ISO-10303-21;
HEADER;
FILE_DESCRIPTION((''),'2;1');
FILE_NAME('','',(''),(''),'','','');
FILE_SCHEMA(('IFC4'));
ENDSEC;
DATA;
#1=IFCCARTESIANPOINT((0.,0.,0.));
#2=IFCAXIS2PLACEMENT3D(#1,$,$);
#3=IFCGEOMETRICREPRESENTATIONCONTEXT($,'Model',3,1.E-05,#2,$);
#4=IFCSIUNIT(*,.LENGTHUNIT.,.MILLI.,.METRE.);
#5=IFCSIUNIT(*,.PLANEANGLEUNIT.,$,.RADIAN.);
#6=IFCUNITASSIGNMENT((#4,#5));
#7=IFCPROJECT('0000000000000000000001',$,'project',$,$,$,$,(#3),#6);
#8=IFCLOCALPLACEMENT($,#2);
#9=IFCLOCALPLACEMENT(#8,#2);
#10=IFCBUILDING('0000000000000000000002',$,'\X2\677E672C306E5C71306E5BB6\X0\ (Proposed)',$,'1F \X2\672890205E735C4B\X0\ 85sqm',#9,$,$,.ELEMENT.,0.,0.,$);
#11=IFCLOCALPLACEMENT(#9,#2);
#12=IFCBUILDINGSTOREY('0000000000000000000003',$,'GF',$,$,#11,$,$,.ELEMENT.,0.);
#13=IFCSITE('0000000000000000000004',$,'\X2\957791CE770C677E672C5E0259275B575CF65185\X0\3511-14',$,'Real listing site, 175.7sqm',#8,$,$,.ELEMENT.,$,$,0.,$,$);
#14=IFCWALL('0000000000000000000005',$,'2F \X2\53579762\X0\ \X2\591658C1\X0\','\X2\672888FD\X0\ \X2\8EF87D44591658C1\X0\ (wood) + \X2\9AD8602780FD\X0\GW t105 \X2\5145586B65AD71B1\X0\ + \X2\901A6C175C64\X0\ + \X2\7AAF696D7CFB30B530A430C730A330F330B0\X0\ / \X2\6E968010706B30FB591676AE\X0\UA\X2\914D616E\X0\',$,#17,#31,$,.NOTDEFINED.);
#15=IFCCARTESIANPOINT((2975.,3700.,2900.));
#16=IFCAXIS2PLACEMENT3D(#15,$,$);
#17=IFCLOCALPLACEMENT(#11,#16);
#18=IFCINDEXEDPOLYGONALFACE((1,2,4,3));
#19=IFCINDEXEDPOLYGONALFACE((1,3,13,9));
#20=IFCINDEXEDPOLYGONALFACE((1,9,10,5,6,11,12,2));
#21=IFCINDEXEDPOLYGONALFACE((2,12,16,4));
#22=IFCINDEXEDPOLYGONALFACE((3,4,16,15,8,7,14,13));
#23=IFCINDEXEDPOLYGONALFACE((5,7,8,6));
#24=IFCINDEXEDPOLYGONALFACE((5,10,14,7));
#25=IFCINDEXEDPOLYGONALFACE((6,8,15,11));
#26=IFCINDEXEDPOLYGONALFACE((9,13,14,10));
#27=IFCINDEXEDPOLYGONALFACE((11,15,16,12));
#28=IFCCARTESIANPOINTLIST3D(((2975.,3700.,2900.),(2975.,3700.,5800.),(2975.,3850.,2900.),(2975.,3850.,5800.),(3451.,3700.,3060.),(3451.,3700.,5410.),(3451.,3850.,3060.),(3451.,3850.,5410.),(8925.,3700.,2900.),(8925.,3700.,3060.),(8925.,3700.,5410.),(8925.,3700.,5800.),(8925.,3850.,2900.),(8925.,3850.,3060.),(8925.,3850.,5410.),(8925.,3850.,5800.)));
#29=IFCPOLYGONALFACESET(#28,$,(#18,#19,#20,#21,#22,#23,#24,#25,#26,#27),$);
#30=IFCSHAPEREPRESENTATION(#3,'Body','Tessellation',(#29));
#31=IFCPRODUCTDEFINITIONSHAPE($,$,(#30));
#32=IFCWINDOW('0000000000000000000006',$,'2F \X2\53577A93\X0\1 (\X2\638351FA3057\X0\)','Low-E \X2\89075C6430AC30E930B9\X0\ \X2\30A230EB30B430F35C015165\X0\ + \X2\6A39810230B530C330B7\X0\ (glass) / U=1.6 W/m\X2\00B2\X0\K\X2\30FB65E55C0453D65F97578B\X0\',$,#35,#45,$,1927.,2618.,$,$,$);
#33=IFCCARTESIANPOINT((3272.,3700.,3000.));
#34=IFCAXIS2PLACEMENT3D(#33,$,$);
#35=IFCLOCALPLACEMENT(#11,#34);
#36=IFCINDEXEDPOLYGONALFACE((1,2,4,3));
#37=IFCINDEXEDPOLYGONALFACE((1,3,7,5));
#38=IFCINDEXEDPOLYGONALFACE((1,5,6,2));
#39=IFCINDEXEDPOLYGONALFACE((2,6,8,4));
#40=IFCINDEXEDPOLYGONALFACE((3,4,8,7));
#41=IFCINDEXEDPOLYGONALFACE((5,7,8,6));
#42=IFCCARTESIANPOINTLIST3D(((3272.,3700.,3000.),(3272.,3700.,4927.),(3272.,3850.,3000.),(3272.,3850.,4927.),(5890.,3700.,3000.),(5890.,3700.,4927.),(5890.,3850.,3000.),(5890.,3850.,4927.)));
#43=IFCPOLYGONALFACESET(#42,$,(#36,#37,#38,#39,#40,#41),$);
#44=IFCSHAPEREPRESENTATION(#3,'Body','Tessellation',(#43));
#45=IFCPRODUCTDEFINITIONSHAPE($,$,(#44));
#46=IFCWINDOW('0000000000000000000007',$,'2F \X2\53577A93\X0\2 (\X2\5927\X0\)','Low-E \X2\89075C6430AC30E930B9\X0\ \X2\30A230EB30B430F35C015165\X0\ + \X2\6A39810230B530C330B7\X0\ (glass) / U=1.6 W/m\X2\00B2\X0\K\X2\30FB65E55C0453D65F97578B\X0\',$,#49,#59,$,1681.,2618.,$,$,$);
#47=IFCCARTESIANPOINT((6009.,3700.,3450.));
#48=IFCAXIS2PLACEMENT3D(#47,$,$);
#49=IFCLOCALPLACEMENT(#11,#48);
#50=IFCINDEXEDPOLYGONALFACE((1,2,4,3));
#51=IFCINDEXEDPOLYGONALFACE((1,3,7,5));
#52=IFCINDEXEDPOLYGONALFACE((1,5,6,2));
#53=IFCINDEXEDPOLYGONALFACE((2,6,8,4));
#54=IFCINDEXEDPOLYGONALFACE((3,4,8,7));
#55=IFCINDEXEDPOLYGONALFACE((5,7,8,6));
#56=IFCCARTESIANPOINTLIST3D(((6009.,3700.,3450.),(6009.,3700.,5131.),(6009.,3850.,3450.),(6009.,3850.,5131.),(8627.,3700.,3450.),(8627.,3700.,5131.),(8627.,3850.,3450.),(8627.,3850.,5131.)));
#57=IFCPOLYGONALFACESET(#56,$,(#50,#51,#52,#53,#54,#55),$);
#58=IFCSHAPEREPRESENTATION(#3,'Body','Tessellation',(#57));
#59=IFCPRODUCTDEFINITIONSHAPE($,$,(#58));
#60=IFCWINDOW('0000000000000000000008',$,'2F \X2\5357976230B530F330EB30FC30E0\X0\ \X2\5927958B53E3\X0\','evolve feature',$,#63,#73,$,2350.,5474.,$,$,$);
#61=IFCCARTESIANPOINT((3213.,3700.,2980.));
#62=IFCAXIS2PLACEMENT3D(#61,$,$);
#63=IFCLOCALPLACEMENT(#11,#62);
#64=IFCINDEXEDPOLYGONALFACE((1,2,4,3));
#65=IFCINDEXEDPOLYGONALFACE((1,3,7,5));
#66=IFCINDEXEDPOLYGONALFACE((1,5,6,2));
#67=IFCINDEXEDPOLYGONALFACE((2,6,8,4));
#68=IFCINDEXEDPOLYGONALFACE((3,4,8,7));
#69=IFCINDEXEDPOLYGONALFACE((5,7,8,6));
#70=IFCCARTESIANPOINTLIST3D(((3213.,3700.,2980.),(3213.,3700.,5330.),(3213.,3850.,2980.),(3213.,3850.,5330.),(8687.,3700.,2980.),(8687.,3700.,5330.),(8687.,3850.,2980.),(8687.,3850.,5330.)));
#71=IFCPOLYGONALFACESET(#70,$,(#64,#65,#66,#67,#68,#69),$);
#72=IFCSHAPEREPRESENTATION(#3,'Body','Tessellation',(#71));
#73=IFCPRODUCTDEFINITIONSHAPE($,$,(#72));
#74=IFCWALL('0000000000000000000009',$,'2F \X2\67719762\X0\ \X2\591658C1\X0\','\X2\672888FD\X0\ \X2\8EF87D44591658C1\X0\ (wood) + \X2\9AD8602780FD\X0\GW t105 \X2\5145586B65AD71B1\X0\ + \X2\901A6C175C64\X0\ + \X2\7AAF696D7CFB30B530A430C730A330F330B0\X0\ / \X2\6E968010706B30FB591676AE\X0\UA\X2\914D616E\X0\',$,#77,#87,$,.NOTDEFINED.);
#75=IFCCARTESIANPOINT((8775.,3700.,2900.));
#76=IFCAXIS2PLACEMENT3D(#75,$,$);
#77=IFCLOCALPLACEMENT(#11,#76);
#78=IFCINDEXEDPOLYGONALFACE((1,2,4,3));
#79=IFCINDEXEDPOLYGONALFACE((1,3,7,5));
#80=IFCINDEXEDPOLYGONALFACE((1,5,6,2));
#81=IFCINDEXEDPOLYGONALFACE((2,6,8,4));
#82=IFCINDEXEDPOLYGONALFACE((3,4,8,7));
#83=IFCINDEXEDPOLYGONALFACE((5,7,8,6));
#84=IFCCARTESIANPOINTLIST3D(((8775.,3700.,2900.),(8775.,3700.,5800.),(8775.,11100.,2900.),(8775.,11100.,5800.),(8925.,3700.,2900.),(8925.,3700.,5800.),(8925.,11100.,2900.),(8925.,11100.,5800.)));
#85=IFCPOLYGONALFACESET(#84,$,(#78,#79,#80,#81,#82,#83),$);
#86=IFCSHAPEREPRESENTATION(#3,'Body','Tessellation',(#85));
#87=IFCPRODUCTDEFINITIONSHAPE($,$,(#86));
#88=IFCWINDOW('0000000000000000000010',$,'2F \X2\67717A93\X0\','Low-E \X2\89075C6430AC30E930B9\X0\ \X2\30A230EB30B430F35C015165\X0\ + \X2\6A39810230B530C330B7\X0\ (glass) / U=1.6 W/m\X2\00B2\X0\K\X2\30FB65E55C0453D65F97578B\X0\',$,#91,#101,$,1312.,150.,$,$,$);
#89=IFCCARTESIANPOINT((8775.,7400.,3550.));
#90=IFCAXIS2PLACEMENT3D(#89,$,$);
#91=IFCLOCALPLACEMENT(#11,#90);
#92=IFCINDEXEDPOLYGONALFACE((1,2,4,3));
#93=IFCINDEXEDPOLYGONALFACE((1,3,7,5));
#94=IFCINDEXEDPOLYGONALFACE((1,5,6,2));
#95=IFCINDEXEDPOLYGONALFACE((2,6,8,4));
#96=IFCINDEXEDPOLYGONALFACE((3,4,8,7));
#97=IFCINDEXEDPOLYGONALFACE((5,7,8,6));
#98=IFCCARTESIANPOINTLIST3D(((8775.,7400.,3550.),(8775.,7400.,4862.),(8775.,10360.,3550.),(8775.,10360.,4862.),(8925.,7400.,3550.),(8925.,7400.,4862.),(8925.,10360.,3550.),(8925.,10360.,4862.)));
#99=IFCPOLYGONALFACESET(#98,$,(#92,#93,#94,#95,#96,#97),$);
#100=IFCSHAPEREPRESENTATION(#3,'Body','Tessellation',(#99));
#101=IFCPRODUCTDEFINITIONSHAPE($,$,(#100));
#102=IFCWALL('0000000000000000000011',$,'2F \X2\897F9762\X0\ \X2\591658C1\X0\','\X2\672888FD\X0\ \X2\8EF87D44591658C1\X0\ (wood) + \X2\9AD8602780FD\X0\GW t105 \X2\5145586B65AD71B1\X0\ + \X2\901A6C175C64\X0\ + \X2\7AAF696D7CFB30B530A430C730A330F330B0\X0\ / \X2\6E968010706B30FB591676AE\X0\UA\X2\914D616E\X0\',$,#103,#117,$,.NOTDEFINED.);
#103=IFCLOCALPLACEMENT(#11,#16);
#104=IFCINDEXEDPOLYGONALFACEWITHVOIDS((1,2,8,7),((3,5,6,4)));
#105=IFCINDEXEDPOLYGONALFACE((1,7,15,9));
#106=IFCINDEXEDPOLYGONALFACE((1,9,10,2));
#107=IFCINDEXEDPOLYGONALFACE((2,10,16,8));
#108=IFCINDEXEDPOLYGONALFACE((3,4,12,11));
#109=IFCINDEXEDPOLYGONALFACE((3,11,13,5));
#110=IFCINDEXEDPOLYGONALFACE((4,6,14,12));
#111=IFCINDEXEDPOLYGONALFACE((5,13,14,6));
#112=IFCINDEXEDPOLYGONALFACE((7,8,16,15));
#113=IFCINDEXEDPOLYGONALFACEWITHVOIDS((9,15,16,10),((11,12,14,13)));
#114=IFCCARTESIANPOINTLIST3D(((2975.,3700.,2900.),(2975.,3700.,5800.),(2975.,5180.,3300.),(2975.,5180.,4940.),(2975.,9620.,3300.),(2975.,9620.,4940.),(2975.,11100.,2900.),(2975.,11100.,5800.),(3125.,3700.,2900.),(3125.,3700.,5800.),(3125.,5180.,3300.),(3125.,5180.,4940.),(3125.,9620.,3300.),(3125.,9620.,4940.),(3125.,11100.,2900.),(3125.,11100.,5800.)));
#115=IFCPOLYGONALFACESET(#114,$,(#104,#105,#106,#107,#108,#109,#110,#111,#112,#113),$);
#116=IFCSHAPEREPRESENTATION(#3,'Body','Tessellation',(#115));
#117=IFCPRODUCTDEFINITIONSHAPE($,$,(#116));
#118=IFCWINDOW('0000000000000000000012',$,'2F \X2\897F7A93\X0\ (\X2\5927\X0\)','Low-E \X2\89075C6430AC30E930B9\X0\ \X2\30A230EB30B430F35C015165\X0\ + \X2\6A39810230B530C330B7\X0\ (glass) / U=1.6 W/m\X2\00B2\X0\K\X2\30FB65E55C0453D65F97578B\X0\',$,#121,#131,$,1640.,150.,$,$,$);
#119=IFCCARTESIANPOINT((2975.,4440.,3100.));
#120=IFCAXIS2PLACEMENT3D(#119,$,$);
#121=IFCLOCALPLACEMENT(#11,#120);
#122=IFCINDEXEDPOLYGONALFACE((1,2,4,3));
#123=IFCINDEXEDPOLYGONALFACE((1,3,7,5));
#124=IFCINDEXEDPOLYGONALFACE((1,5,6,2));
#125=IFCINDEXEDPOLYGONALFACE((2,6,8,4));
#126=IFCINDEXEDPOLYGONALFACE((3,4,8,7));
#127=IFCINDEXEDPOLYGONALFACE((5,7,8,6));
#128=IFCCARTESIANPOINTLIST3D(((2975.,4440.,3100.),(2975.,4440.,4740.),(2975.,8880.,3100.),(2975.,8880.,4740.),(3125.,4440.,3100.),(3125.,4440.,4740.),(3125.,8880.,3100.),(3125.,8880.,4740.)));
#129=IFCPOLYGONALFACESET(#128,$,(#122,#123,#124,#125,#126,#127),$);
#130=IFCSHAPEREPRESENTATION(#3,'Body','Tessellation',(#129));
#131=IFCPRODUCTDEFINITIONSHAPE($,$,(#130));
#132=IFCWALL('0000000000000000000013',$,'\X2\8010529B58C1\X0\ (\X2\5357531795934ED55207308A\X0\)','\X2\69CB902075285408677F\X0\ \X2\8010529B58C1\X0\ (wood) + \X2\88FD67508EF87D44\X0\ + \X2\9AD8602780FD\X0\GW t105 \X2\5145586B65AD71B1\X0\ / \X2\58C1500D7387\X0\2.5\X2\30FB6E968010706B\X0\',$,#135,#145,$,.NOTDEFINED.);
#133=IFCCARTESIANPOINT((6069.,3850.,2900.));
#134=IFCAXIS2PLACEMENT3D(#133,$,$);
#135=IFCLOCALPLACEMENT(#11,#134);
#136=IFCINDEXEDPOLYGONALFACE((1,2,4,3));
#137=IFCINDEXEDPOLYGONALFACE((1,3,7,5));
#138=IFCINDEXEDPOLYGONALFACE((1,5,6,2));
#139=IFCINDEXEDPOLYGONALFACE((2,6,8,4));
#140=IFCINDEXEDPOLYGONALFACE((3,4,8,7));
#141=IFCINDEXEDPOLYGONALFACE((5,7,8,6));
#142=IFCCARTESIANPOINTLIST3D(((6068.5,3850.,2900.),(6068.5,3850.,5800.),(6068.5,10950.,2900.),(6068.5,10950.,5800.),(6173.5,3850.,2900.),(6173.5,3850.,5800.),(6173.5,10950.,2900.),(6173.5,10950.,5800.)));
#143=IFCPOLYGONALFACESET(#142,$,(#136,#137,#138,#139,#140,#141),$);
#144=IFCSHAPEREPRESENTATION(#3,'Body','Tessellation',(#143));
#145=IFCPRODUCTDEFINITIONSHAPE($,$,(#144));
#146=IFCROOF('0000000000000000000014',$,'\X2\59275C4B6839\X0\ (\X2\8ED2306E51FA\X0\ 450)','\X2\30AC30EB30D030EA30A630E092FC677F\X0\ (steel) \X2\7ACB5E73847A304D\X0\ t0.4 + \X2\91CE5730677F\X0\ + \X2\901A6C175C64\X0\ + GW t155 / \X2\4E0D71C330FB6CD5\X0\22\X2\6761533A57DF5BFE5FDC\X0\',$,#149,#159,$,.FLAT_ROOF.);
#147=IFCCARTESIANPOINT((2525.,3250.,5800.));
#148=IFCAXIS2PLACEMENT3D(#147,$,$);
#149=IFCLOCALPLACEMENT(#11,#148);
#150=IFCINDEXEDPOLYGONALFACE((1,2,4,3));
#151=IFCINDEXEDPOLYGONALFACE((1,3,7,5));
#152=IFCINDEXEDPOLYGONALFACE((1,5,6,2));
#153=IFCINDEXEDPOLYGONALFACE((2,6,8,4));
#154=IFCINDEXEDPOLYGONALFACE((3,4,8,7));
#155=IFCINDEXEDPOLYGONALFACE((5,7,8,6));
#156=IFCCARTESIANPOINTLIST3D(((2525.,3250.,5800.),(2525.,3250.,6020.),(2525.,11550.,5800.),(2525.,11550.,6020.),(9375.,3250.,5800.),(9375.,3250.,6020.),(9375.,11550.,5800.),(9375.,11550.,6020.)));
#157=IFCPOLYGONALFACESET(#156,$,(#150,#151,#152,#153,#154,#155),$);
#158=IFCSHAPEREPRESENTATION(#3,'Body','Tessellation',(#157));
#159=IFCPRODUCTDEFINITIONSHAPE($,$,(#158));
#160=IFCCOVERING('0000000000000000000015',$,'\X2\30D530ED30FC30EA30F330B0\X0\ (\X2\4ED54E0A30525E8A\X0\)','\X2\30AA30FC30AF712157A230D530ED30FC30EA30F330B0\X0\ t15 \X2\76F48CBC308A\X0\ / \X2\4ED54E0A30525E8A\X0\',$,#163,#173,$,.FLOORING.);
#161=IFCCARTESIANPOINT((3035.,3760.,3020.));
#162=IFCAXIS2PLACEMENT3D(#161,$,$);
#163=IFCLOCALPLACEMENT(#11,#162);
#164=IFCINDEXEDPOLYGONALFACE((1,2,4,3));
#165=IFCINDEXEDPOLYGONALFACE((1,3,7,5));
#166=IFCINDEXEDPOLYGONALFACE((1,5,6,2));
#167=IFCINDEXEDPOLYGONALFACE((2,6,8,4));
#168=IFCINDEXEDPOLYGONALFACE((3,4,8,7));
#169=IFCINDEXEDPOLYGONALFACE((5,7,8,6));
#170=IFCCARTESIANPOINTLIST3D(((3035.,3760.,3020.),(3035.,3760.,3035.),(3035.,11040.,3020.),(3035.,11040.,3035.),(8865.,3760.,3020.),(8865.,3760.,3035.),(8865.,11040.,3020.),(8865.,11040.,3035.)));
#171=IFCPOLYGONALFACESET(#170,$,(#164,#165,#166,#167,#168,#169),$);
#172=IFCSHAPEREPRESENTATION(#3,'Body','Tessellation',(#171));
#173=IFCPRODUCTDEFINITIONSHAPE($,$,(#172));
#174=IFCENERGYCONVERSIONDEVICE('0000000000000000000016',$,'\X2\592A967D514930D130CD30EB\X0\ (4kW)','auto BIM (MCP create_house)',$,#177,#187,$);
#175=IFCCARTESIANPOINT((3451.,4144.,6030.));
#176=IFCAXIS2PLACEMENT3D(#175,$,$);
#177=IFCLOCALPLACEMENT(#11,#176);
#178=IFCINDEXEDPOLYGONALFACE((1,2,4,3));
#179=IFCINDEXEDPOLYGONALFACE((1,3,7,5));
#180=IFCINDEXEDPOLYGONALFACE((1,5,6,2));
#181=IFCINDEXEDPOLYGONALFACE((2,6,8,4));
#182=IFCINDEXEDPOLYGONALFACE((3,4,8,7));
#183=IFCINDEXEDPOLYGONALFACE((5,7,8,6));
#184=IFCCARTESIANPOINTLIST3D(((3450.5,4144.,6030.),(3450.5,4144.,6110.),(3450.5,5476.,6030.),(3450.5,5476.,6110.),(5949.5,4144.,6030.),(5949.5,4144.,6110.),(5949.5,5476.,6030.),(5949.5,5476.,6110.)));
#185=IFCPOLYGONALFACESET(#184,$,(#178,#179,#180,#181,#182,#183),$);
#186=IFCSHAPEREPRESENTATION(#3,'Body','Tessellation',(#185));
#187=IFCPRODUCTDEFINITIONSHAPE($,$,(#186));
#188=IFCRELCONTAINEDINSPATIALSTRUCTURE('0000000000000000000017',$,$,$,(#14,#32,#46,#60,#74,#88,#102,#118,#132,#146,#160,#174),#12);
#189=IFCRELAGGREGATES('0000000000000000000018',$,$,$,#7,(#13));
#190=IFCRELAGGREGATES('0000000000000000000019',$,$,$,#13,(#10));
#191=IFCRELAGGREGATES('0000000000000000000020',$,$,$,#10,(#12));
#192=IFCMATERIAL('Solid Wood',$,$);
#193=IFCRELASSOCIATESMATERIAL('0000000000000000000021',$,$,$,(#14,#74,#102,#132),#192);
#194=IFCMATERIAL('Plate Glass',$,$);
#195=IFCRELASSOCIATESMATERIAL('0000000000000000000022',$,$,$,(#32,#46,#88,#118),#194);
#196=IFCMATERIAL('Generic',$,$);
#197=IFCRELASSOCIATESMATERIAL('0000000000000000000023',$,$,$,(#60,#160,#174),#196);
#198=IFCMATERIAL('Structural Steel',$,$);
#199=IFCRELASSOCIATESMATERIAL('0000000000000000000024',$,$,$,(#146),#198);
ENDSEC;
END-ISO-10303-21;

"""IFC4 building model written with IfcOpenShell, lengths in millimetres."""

from ifc_helpers import new_model, si_unit, frame, frame_2d, origin, place, context, project, spatial, rectangle, extrude, material, element, fill, save


model = new_model("IFC4")

# Units and contexts
model_context = context("Model", 3, precision=1e-05, world=origin())
ifc_project = project(units=[si_unit("LENGTHUNIT", "METRE", prefix="MILLI"), si_unit("PLANEANGLEUNIT", "RADIAN")], contexts=[model_context])

# Site, building, storey
site_placement = place(None, origin())
site = spatial("IfcSite", under=ifc_project, at=site_placement, Name="長野県松本市大字島内3511-14", ObjectType="Real listing site, 175.7sqm", CompositionType="ELEMENT", RefElevation=0.0)
building_placement = place(site_placement, origin())
building = spatial("IfcBuilding", under=site, at=building_placement, Name="松本の山の家 (Proposed)", ObjectType="1F 木造平屋 85sqm", CompositionType="ELEMENT", ElevationOfRefHeight=0.0, ElevationOfTerrain=0.0)
storey_placement = place(building_placement, origin())
storey = spatial("IfcBuildingStorey", under=building, at=storey_placement, Name="GF", CompositionType="ELEMENT", Elevation=0.0)

# Shared definitions
ifc_material_1 = material(Name="Solid Wood")

# Wall, openings, windows
wall_1_placement = place(storey_placement, frame((2975.0, 3700.0, 2900.0)))
wall_1 = element("IfcWall", 1, at=wall_1_placement, inside=storey, material=ifc_material_1, Name="2F 南面 外壁", Description="木製 軸組外壁 (wood) + 高性能GW t105 充填断熱 + 通気層 + 窯業系サイディング / 準耐火・外皮UA配慮", PredefinedType="NOTDEFINED", context=model_context, shape_type="SweptSolid", body=[
    extrude(rectangle(XDim=5950.0, YDim=150.0, at=frame_2d((2975.0, 75.0))), frame((2975.0, 3700.0, 2900.0)), (0.0, 0.0, 1.0), 2900.0),
])
opening_1_placement = place(storey_placement, frame((3272.0, 3700.0, 3000.0)))
opening_1 = element("IfcOpeningElement", 2, at=opening_1_placement, cuts=wall_1, PredefinedType="NOTDEFINED", context=model_context, shape_type="SweptSolid", body=[
    extrude(rectangle(XDim=2618.0, YDim=150.0, at=frame_2d((1309.0, 75.0))), frame((3272.0, 3700.0, 3000.0)), (0.0, 0.0, 1.0), 1927.0),
])
opening_2_placement = place(storey_placement, frame((6009.0, 3700.0, 3450.0)))
opening_2 = element("IfcOpeningElement", 3, at=opening_2_placement, cuts=wall_1, PredefinedType="NOTDEFINED", context=model_context, shape_type="SweptSolid", body=[
    extrude(rectangle(XDim=2618.0, YDim=150.0, at=frame_2d((1309.0, 75.0))), frame((6009.0, 3700.0, 3450.0)), (0.0, 0.0, 1.0), 1681.0),
])
opening_3_placement = place(storey_placement, frame((3213.0, 3700.0, 2980.0)))
opening_3 = element("IfcOpeningElement", 4, at=opening_3_placement, cuts=wall_1, PredefinedType="NOTDEFINED", context=model_context, shape_type="SweptSolid", body=[
    extrude(rectangle(XDim=5474.0, YDim=150.0, at=frame_2d((2737.0, 75.0))), frame((3213.0, 3700.0, 2980.0)), (0.0, 0.0, 1.0), 2350.0),
])
ifc_material_2 = material(Name="Plate Glass")
window_1_placement = place(storey_placement, frame((3272.0, 3700.0, 3000.0)))
window_1 = element("IfcWindow", 5, at=window_1_placement, inside=storey, material=ifc_material_2, Name="2F 南窓1 (掃出し)", Description="Low-E 複層ガラス アルゴン封入 + 樹脂サッシ (glass) / U=1.6 W/m²K・日射取得型", OverallHeight=1927.0, OverallWidth=2618.0, context=model_context, shape_type="SweptSolid", body=[
    extrude(rectangle(XDim=2618.0, YDim=150.0, at=frame_2d((1309.0, 75.0))), frame((3272.0, 3700.0, 3000.0)), (0.0, 0.0, 1.0), 1927.0),
])
fill(opening_1, window_1)
window_2_placement = place(storey_placement, frame((6009.0, 3700.0, 3450.0)))
window_2 = element("IfcWindow", 6, at=window_2_placement, inside=storey, material=ifc_material_2, Name="2F 南窓2 (大)", Description="Low-E 複層ガラス アルゴン封入 + 樹脂サッシ (glass) / U=1.6 W/m²K・日射取得型", OverallHeight=1681.0, OverallWidth=2618.0, context=model_context, shape_type="SweptSolid", body=[
    extrude(rectangle(XDim=2618.0, YDim=150.0, at=frame_2d((1309.0, 75.0))), frame((6009.0, 3700.0, 3450.0)), (0.0, 0.0, 1.0), 1681.0),
])
fill(opening_2, window_2)
ifc_material_3 = material(Name="Generic")
window_3_placement = place(storey_placement, frame((3213.0, 3700.0, 2980.0)))
window_3 = element("IfcWindow", 7, at=window_3_placement, inside=storey, material=ifc_material_3, Name="2F 南面サンルーム 大開口", Description="evolve feature", OverallHeight=2350.0, OverallWidth=5474.0, context=model_context, shape_type="SweptSolid", body=[
    extrude(rectangle(XDim=5474.0, YDim=150.0, at=frame_2d((2737.0, 75.0))), frame((3213.0, 3700.0, 2980.0)), (0.0, 0.0, 1.0), 2350.0),
])
fill(opening_3, window_3)

# Walls, openings, windows
wall_2_placement = place(storey_placement, frame((8775.0, 3700.0, 2900.0)))
wall_2 = element("IfcWall", 8, at=wall_2_placement, inside=storey, material=ifc_material_1, Name="2F 東面 外壁", Description="木製 軸組外壁 (wood) + 高性能GW t105 充填断熱 + 通気層 + 窯業系サイディング / 準耐火・外皮UA配慮", PredefinedType="NOTDEFINED", context=model_context, shape_type="SweptSolid", body=[
    extrude(rectangle(XDim=150.0, YDim=7400.0, at=frame_2d((75.0, 3700.0))), frame((8775.0, 3700.0, 2900.0)), (0.0, 0.0, 1.0), 2900.0),
])
opening_4_placement = place(storey_placement, frame((8775.0, 7400.0, 3550.0)))
opening_4 = element("IfcOpeningElement", 9, at=opening_4_placement, cuts=wall_2, PredefinedType="NOTDEFINED", context=model_context, shape_type="SweptSolid", body=[
    extrude(rectangle(XDim=150.0, YDim=2960.0, at=frame_2d((75.0, 1480.0))), frame((8775.0, 7400.0, 3550.0)), (0.0, 0.0, 1.0), 1312.0),
])
window_4_placement = place(storey_placement, frame((8775.0, 7400.0, 3550.0)))
window_4 = element("IfcWindow", 10, at=window_4_placement, inside=storey, material=ifc_material_2, Name="2F 東窓", Description="Low-E 複層ガラス アルゴン封入 + 樹脂サッシ (glass) / U=1.6 W/m²K・日射取得型", OverallHeight=1312.0, OverallWidth=150.0, context=model_context, shape_type="SweptSolid", body=[
    extrude(rectangle(XDim=150.0, YDim=2960.0, at=frame_2d((75.0, 1480.0))), frame((8775.0, 7400.0, 3550.0)), (0.0, 0.0, 1.0), 1312.0),
])
fill(opening_4, window_4)
wall_3_placement = place(storey_placement, frame((2975.0, 3700.0, 2900.0)))
wall_3 = element("IfcWall", 11, at=wall_3_placement, inside=storey, material=ifc_material_1, Name="2F 西面 外壁", Description="木製 軸組外壁 (wood) + 高性能GW t105 充填断熱 + 通気層 + 窯業系サイディング / 準耐火・外皮UA配慮", PredefinedType="NOTDEFINED", context=model_context, shape_type="SweptSolid", body=[
    extrude(rectangle(XDim=150.0, YDim=7400.0, at=frame_2d((75.0, 3700.0))), frame((2975.0, 3700.0, 2900.0)), (0.0, 0.0, 1.0), 2900.0),
])
opening_5_placement = place(storey_placement, frame((2975.0, 4440.0, 3100.0)))
opening_5 = element("IfcOpeningElement", 12, at=opening_5_placement, cuts=wall_3, PredefinedType="NOTDEFINED", context=model_context, shape_type="SweptSolid", body=[
    extrude(rectangle(XDim=150.0, YDim=4440.0, at=frame_2d((75.0, 2220.0))), frame((2975.0, 4440.0, 3100.0)), (0.0, 0.0, 1.0), 1640.0),
])
window_5_placement = place(storey_placement, frame((2975.0, 4440.0, 3100.0)))
window_5 = element("IfcWindow", 13, at=window_5_placement, inside=storey, material=ifc_material_2, Name="2F 西窓 (大)", Description="Low-E 複層ガラス アルゴン封入 + 樹脂サッシ (glass) / U=1.6 W/m²K・日射取得型", OverallHeight=1640.0, OverallWidth=150.0, context=model_context, shape_type="SweptSolid", body=[
    extrude(rectangle(XDim=150.0, YDim=4440.0, at=frame_2d((75.0, 2220.0))), frame((2975.0, 4440.0, 3100.0)), (0.0, 0.0, 1.0), 1640.0),
])
fill(opening_5, window_5)

# Wall
wall_4_placement = place(storey_placement, frame((6069.0, 3850.0, 2900.0)))
element("IfcWall", 14, at=wall_4_placement, inside=storey, material=ifc_material_1, Name="耐力壁 (南北間仕切り)", Description="構造用合板 耐力壁 (wood) + 製材軸組 + 高性能GW t105 充填断熱 / 壁倍率2.5・準耐火", PredefinedType="NOTDEFINED", context=model_context, shape_type="SweptSolid", body=[
    extrude(rectangle(XDim=105.0, YDim=7100.0, at=frame_2d((52.0, 3550.0))), frame((6069.0, 3850.0, 2900.0)), (0.0, 0.0, 1.0), 2900.0),
])

# Roof
ifc_material_4 = material(Name="Structural Steel")
roof_placement = place(storey_placement, frame((2525.0, 3250.0, 5800.0)))
element("IfcRoof", 15, at=roof_placement, inside=storey, material=ifc_material_4, Name="大屋根 (軒の出 450)", Description="ガルバリウム鋼板 (steel) 立平葺き t0.4 + 野地板 + 通気層 + GW t155 / 不燃・法22条区域対応", PredefinedType="FLAT_ROOF", context=model_context, shape_type="SweptSolid", body=[
    extrude(rectangle(XDim=6850.0, YDim=8300.0, at=frame_2d((3425.0, 4150.0))), frame((2525.0, 3250.0, 5800.0)), (0.0, 0.0, 1.0), 220.0),
])

# Covering
covering_placement = place(storey_placement, frame((3035.0, 3760.0, 3020.0)))
element("IfcCovering", 16, at=covering_placement, inside=storey, material=ifc_material_3, Name="フローリング (仕上げ床)", Description="オーク無垢フローリング t15 直貼り / 仕上げ床", PredefinedType="FLOORING", context=model_context, shape_type="SweptSolid", body=[
    extrude(rectangle(XDim=5830.0, YDim=7280.0, at=frame_2d((2915.0, 3640.0))), frame((3035.0, 3760.0, 3020.0)), (0.0, 0.0, 1.0), 15.0),
])

# Energy conversion device
energy_conversion_device_placement = place(storey_placement, frame((3451.0, 4144.0, 6030.0)))
element("IfcEnergyConversionDevice", 17, at=energy_conversion_device_placement, inside=storey, material=ifc_material_3, Name="太陽光パネル (4kW)", Description="auto BIM (MCP create_house)", context=model_context, shape_type="SweptSolid", body=[
    extrude(rectangle(XDim=2499.0, YDim=1332.0, at=frame_2d((1249.0, 666.0))), frame((3451.0, 4144.0, 6030.0)), (0.0, 0.0, 1.0), 80.0),
])

save(model, "model.ifc")
